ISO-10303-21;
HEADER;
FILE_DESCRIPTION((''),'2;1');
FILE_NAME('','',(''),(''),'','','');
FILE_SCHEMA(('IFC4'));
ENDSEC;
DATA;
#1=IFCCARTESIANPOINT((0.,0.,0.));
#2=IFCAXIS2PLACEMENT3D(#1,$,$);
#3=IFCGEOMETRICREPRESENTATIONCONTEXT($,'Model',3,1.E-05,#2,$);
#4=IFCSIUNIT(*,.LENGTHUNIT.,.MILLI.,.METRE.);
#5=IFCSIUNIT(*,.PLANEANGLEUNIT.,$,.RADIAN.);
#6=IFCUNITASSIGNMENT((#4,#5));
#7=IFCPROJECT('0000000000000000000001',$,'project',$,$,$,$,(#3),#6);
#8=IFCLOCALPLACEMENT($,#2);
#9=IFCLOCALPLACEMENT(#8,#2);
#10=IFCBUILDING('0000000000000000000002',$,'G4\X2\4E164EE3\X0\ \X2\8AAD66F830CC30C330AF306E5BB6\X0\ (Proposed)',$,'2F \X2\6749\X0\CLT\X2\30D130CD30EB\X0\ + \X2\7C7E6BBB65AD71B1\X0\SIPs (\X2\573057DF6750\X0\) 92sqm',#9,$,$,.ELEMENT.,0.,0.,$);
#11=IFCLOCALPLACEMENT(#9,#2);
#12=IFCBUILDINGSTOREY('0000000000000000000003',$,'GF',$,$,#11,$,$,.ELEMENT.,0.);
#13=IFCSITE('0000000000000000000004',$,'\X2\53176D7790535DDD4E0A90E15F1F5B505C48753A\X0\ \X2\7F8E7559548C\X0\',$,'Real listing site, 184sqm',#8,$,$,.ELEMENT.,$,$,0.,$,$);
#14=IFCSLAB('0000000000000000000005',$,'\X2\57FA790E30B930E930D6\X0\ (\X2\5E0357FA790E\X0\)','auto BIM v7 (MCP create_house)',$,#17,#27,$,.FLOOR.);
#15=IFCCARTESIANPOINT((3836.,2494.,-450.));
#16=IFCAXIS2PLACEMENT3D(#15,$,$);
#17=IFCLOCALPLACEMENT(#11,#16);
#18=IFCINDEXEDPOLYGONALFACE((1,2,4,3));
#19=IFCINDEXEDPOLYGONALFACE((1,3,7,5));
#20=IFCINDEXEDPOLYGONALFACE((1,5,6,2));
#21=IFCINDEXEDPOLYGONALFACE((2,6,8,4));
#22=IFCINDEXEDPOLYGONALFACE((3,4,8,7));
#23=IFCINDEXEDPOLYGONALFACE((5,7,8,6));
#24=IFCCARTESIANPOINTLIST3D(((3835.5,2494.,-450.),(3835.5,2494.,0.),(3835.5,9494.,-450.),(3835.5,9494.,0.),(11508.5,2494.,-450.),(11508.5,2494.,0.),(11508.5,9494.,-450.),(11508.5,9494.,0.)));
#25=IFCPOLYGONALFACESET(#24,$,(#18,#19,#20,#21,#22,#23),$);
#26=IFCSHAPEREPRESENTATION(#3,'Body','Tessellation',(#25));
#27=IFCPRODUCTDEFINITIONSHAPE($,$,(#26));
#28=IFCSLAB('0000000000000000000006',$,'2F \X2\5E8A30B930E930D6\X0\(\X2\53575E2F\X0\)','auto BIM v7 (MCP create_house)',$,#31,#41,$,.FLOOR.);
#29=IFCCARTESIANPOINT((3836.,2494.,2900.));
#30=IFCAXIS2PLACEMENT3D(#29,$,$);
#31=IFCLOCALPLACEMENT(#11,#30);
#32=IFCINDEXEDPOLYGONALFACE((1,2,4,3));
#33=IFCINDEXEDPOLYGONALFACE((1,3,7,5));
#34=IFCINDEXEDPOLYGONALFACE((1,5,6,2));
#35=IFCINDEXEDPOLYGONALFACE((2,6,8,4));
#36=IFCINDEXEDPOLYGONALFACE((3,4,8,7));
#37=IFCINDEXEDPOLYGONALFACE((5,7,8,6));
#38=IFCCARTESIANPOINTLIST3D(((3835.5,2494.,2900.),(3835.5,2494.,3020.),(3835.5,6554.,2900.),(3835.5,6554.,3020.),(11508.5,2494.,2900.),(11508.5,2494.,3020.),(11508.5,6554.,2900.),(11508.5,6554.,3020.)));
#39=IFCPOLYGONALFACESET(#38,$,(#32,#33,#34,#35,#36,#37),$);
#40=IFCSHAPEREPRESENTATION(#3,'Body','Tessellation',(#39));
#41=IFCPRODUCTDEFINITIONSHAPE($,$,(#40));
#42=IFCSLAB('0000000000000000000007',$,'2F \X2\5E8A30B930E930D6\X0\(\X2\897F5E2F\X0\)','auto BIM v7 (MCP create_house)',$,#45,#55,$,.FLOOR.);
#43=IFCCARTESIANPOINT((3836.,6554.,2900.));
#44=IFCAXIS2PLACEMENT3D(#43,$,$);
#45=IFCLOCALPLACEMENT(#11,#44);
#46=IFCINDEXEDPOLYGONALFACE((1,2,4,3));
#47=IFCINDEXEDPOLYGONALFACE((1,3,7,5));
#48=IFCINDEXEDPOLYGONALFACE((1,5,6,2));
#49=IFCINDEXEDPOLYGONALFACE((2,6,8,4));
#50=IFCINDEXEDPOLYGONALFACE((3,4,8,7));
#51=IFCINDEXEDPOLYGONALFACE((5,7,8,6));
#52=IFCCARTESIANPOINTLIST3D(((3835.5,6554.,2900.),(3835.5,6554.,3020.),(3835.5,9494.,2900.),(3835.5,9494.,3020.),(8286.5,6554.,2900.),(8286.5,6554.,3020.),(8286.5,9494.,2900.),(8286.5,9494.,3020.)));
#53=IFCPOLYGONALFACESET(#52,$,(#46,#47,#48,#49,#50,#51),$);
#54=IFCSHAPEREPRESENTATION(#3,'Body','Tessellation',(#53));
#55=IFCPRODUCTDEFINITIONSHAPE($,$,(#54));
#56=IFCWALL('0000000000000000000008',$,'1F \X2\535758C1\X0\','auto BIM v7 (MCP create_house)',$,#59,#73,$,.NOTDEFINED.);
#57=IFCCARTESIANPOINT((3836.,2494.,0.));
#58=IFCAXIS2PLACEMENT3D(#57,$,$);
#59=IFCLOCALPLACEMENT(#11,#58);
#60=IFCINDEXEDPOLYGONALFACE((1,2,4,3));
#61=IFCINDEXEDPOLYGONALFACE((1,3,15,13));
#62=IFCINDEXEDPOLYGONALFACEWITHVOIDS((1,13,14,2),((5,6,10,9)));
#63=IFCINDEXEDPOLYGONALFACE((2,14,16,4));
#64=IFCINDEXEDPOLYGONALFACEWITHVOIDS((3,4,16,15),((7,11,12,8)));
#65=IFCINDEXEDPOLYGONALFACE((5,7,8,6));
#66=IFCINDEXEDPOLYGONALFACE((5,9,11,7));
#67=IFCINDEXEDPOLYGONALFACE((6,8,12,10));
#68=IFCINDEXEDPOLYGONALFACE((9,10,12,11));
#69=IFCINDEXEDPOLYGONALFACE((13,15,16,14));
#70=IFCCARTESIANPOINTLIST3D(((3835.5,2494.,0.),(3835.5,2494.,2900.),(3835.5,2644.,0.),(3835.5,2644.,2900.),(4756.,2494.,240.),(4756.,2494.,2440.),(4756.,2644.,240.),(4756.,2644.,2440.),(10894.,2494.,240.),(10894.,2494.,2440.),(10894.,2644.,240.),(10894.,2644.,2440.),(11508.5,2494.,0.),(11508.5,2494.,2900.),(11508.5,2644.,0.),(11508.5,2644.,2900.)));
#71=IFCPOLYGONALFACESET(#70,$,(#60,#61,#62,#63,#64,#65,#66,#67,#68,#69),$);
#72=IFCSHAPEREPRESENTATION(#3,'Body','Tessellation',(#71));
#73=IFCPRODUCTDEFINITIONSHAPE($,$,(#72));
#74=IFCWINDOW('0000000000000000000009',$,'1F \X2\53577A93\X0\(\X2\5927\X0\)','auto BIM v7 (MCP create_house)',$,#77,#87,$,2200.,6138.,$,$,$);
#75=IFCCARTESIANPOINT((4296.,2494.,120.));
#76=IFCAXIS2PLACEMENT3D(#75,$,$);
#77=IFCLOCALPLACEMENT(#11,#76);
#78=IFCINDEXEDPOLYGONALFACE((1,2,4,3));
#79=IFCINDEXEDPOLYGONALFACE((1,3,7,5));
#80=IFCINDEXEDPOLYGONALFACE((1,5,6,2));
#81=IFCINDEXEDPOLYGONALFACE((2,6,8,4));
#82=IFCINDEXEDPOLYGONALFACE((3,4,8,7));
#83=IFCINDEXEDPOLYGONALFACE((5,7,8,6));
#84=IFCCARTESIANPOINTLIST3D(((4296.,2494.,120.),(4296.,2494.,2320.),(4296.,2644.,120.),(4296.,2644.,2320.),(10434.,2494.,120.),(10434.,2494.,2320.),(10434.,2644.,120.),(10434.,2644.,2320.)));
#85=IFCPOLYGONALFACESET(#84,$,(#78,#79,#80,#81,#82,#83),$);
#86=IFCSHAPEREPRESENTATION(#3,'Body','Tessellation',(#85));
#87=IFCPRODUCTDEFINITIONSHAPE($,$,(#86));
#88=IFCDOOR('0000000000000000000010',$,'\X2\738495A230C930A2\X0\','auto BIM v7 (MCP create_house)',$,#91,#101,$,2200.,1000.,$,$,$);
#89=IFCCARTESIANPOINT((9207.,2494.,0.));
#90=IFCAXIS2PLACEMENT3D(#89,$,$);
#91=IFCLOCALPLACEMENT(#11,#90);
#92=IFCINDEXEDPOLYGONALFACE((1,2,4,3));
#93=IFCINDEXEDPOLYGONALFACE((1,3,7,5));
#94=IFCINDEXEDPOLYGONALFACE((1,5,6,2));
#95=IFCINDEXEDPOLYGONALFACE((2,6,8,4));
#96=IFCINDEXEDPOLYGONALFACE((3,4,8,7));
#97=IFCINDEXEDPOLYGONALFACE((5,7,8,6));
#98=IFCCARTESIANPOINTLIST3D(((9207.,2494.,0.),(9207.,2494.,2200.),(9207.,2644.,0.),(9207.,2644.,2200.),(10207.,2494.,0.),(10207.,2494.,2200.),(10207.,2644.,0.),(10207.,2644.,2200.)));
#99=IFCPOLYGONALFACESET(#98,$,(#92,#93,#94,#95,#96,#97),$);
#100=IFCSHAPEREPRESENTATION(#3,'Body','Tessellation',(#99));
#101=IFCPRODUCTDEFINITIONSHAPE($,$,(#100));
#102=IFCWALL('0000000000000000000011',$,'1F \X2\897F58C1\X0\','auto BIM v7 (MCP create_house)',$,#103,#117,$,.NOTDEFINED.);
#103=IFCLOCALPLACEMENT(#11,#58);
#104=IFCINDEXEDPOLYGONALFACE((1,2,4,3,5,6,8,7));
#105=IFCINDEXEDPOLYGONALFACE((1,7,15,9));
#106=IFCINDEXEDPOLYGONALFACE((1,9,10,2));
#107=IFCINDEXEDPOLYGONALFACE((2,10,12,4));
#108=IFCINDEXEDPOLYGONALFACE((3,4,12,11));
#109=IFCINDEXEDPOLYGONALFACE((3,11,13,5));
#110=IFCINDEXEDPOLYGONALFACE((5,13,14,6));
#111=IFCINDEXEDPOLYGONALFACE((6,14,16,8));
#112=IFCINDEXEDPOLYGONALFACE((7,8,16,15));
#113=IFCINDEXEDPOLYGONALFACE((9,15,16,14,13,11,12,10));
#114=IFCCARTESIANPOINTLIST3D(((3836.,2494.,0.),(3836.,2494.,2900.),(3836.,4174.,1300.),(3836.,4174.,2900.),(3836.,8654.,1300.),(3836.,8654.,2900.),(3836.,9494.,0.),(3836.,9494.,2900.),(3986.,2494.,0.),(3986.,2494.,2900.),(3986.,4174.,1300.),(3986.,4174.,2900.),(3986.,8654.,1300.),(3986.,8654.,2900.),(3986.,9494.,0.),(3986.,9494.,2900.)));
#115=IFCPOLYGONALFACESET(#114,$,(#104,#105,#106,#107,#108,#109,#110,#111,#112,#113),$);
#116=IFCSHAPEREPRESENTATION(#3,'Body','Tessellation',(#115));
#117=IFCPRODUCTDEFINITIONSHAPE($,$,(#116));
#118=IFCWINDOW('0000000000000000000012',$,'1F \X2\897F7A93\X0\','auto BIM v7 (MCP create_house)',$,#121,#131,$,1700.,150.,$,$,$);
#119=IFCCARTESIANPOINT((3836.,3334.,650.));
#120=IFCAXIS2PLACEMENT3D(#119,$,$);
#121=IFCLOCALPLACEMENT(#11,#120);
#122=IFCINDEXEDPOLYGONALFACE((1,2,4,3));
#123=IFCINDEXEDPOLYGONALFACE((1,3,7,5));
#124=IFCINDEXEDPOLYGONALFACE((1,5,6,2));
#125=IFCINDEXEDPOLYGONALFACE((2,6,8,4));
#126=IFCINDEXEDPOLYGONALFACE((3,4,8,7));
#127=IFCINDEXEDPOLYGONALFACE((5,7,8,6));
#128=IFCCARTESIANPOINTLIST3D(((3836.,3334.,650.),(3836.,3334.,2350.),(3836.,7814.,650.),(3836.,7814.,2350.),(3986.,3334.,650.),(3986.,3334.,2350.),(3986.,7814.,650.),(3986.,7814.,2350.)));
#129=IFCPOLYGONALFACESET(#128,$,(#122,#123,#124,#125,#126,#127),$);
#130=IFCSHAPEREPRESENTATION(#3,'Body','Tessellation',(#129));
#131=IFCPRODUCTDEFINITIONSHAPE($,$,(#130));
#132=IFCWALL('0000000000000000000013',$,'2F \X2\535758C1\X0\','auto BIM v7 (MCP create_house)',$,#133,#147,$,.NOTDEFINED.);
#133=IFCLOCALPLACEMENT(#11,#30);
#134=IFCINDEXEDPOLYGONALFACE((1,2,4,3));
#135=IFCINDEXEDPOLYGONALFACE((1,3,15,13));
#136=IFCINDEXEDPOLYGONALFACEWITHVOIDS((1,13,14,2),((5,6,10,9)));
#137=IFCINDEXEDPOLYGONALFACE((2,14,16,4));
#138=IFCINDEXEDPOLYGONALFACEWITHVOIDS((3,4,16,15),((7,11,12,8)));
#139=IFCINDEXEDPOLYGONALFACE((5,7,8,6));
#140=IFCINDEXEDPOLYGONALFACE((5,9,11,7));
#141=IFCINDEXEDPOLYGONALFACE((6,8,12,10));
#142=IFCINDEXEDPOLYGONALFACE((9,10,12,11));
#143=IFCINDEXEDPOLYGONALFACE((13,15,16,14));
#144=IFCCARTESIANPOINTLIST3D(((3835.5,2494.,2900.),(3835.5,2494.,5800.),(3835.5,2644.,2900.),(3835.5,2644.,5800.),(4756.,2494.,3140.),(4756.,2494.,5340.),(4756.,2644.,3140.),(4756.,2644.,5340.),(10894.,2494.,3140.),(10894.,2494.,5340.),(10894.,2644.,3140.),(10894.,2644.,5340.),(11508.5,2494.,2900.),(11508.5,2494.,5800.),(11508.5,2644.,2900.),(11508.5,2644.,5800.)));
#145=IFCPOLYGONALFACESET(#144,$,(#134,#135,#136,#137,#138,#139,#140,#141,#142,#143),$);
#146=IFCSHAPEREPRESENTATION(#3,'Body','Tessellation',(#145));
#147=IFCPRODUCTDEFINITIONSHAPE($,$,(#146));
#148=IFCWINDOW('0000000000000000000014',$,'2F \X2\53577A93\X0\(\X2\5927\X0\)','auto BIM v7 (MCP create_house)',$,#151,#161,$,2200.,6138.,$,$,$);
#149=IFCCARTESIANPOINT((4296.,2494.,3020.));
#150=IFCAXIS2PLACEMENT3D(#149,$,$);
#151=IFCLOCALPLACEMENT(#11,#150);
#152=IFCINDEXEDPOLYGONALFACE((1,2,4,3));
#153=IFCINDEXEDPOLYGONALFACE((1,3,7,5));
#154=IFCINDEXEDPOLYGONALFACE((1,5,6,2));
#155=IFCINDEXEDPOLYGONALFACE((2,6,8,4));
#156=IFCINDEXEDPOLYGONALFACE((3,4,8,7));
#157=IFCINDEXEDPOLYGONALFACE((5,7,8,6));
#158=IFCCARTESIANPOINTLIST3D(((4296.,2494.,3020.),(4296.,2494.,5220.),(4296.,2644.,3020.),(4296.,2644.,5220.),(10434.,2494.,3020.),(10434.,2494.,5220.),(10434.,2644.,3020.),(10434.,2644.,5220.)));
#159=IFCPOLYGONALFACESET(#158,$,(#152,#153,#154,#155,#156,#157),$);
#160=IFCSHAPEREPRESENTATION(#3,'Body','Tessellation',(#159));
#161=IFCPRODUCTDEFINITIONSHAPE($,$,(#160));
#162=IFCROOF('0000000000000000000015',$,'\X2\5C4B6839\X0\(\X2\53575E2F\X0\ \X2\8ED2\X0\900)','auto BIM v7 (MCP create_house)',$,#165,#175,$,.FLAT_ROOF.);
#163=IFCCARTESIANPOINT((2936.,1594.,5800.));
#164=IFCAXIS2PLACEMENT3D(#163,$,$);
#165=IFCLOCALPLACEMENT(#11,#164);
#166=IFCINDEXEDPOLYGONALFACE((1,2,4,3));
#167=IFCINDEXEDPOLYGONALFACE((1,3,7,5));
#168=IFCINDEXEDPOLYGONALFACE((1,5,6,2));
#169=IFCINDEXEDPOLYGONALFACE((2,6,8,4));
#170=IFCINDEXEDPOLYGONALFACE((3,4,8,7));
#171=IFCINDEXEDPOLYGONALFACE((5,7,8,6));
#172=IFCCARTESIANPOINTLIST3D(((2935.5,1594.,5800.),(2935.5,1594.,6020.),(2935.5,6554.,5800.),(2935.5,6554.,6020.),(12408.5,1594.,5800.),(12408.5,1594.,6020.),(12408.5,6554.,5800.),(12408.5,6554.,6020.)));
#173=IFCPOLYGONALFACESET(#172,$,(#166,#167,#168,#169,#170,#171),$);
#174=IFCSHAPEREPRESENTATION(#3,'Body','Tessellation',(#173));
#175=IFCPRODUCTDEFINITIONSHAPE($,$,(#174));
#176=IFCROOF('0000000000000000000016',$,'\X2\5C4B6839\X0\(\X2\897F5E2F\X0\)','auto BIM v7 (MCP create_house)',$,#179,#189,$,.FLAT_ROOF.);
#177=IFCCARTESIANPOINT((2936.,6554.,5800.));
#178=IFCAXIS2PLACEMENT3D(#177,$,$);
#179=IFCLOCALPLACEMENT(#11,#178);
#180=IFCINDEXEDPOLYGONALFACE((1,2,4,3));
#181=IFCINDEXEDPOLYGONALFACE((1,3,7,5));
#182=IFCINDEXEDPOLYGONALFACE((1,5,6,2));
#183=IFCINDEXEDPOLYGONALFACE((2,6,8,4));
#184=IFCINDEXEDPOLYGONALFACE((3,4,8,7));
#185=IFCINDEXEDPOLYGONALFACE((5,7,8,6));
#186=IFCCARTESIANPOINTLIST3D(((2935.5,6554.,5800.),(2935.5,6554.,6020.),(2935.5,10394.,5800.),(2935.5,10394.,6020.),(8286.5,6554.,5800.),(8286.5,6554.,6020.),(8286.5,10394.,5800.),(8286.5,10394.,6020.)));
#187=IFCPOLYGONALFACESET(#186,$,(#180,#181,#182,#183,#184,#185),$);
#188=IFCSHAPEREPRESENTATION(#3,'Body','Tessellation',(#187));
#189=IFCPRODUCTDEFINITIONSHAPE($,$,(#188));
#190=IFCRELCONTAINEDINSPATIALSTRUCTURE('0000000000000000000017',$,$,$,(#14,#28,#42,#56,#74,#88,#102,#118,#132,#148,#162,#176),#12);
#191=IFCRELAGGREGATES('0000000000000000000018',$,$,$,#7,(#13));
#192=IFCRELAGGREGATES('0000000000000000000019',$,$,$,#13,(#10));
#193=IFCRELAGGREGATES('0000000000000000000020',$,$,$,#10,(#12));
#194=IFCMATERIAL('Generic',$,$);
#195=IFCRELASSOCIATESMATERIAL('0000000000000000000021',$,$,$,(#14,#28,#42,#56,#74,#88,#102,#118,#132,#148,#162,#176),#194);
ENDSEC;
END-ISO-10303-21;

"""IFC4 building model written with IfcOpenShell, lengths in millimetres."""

from ifc_helpers import new_model, si_unit, frame, frame_2d, origin, place, context, project, spatial, rectangle, extrude, material, element, fill, save


model = new_model("IFC4")

# Units and contexts
model_context = context("Model", 3, precision=1e-05, world=origin())
ifc_project = project(units=[si_unit("LENGTHUNIT", "METRE", prefix="MILLI"), si_unit("PLANEANGLEUNIT", "RADIAN")], contexts=[model_context])

# Site, building, storey
site_placement = place(None, origin())
site = spatial("IfcSite", under=ifc_project, at=site_placement, Name="北海道川上郡弟子屈町 美留和", ObjectType="Real listing site, 184sqm", CompositionType="ELEMENT", RefElevation=0.0)
building_placement = place(site_placement, origin())
building = spatial("IfcBuilding", under=site, at=building_placement, Name="G4世代 読書ヌックの家 (Proposed)", ObjectType="2F 杉CLTパネル + 籾殻断熱SIPs (地域材) 92sqm", CompositionType="ELEMENT", ElevationOfRefHeight=0.0, ElevationOfTerrain=0.0)
storey_placement = place(building_placement, origin())
storey = spatial("IfcBuildingStorey", under=building, at=storey_placement, Name="GF", CompositionType="ELEMENT", Elevation=0.0)

# Slabs
ifc_material = material(Name="Generic")
slab_1_placement = place(storey_placement, frame((3836.0, 2494.0, -450.0)))
element("IfcSlab", 1, at=slab_1_placement, inside=storey, material=ifc_material, Name="基礎スラブ (布基礎)", Description="auto BIM v7 (MCP create_house)", PredefinedType="FLOOR", context=model_context, shape_type="SweptSolid", body=[
    extrude(rectangle(XDim=7673.0, YDim=7000.0, at=frame_2d((3836.0, 3500.0))), frame((3836.0, 2494.0, -450.0)), (0.0, 0.0, 1.0), 450.0),
])
slab_2_placement = place(storey_placement, frame((3836.0, 2494.0, 2900.0)))
element("IfcSlab", 2, at=slab_2_placement, inside=storey, material=ifc_material, Name="2F 床スラブ(南帯)", Description="auto BIM v7 (MCP create_house)", PredefinedType="FLOOR", context=model_context, shape_type="SweptSolid", body=[
    extrude(rectangle(XDim=7673.0, YDim=4060.0, at=frame_2d((3836.0, 2030.0))), frame((3836.0, 2494.0, 2900.0)), (0.0, 0.0, 1.0), 120.0),
])
slab_3_placement = place(storey_placement, frame((3836.0, 6554.0, 2900.0)))
element("IfcSlab", 3, at=slab_3_placement, inside=storey, material=ifc_material, Name="2F 床スラブ(西帯)", Description="auto BIM v7 (MCP create_house)", PredefinedType="FLOOR", context=model_context, shape_type="SweptSolid", body=[
    extrude(rectangle(XDim=4451.0, YDim=2940.0, at=frame_2d((2225.0, 1470.0))), frame((3836.0, 6554.0, 2900.0)), (0.0, 0.0, 1.0), 120.0),
])

# Wall, openings, window, door
wall_1_placement = place(storey_placement, frame((3836.0, 2494.0, 0.0)))
wall_1 = element("IfcWall", 4, at=wall_1_placement, inside=storey, material=ifc_material, Name="1F 南壁", Description="auto BIM v7 (MCP create_house)", PredefinedType="NOTDEFINED", context=model_context, shape_type="SweptSolid", body=[
    extrude(rectangle(XDim=7673.0, YDim=150.0, at=frame_2d((3836.0, 75.0))), frame((3836.0, 2494.0, 0.0)), (0.0, 0.0, 1.0), 2900.0),
])
opening_1_placement = place(storey_placement, frame((4296.0, 2494.0, 120.0)))
opening_1 = element("IfcOpeningElement", 5, at=opening_1_placement, cuts=wall_1, PredefinedType="NOTDEFINED", context=model_context, shape_type="SweptSolid", body=[
    extrude(rectangle(XDim=6138.0, YDim=150.0, at=frame_2d((3069.0, 75.0))), frame((4296.0, 2494.0, 120.0)), (0.0, 0.0, 1.0), 2200.0),
])
opening_2_placement = place(storey_placement, frame((9207.0, 2494.0, 0.0)))
opening_2 = element("IfcOpeningElement", 6, at=opening_2_placement, cuts=wall_1, PredefinedType="NOTDEFINED", context=model_context, shape_type="SweptSolid", body=[
    extrude(rectangle(XDim=1000.0, YDim=150.0, at=frame_2d((500.0, 75.0))), frame((9207.0, 2494.0, 0.0)), (0.0, 0.0, 1.0), 2200.0),
])
window_1_placement = place(storey_placement, frame((4296.0, 2494.0, 120.0)))
window_1 = element("IfcWindow", 7, at=window_1_placement, inside=storey, material=ifc_material, Name="1F 南窓(大)", Description="auto BIM v7 (MCP create_house)", OverallHeight=2200.0, OverallWidth=6138.0, context=model_context, shape_type="SweptSolid", body=[
    extrude(rectangle(XDim=6138.0, YDim=150.0, at=frame_2d((3069.0, 75.0))), frame((4296.0, 2494.0, 120.0)), (0.0, 0.0, 1.0), 2200.0),
])
fill(opening_1, window_1)
door_placement = place(storey_placement, frame((9207.0, 2494.0, 0.0)))
door = element("IfcDoor", 8, at=door_placement, inside=storey, material=ifc_material, Name="玄関ドア", Description="auto BIM v7 (MCP create_house)", OverallHeight=2200.0, OverallWidth=1000.0, context=model_context, shape_type="SweptSolid", body=[
    extrude(rectangle(XDim=1000.0, YDim=150.0, at=frame_2d((500.0, 75.0))), frame((9207.0, 2494.0, 0.0)), (0.0, 0.0, 1.0), 2200.0),
])
fill(opening_2, door)

# Wall, opening, window
wall_2_placement = place(storey_placement, frame((3836.0, 2494.0, 0.0)))
wall_2 = element("IfcWall", 9, at=wall_2_placement, inside=storey, material=ifc_material, Name="1F 西壁", Description="auto BIM v7 (MCP create_house)", PredefinedType="NOTDEFINED", context=model_context, shape_type="SweptSolid", body=[
    extrude(rectangle(XDim=150.0, YDim=7000.0, at=frame_2d((75.0, 3500.0))), frame((3836.0, 2494.0, 0.0)), (0.0, 0.0, 1.0), 2900.0),
])
opening_3_placement = place(storey_placement, frame((3836.0, 3334.0, 650.0)))
opening_3 = element("IfcOpeningElement", 10, at=opening_3_placement, cuts=wall_2, PredefinedType="NOTDEFINED", context=model_context, shape_type="SweptSolid", body=[
    extrude(rectangle(XDim=150.0, YDim=4480.0, at=frame_2d((75.0, 2240.0))), frame((3836.0, 3334.0, 650.0)), (0.0, 0.0, 1.0), 1700.0),
])
window_2_placement = place(storey_placement, frame((3836.0, 3334.0, 650.0)))
window_2 = element("IfcWindow", 11, at=window_2_placement, inside=storey, material=ifc_material, Name="1F 西窓", Description="auto BIM v7 (MCP create_house)", OverallHeight=1700.0, OverallWidth=150.0, context=model_context, shape_type="SweptSolid", body=[
    extrude(rectangle(XDim=150.0, YDim=4480.0, at=frame_2d((75.0, 2240.0))), frame((3836.0, 3334.0, 650.0)), (0.0, 0.0, 1.0), 1700.0),
])
fill(opening_3, window_2)

# Wall, opening, window
wall_3_placement = place(storey_placement, frame((3836.0, 2494.0, 2900.0)))
wall_3 = element("IfcWall", 12, at=wall_3_placement, inside=storey, material=ifc_material, Name="2F 南壁", Description="auto BIM v7 (MCP create_house)", PredefinedType="NOTDEFINED", context=model_context, shape_type="SweptSolid", body=[
    extrude(rectangle(XDim=7673.0, YDim=150.0, at=frame_2d((3836.0, 75.0))), frame((3836.0, 2494.0, 2900.0)), (0.0, 0.0, 1.0), 2900.0),
])
opening_4_placement = place(storey_placement, frame((4296.0, 2494.0, 3020.0)))
opening_4 = element("IfcOpeningElement", 13, at=opening_4_placement, cuts=wall_3, PredefinedType="NOTDEFINED", context=model_context, shape_type="SweptSolid", body=[
    extrude(rectangle(XDim=6138.0, YDim=150.0, at=frame_2d((3069.0, 75.0))), frame((4296.0, 2494.0, 3020.0)), (0.0, 0.0, 1.0), 2200.0),
])
window_3_placement = place(storey_placement, frame((4296.0, 2494.0, 3020.0)))
window_3 = element("IfcWindow", 14, at=window_3_placement, inside=storey, material=ifc_material, Name="2F 南窓(大)", Description="auto BIM v7 (MCP create_house)", OverallHeight=2200.0, OverallWidth=6138.0, context=model_context, shape_type="SweptSolid", body=[
    extrude(rectangle(XDim=6138.0, YDim=150.0, at=frame_2d((3069.0, 75.0))), frame((4296.0, 2494.0, 3020.0)), (0.0, 0.0, 1.0), 2200.0),
])
fill(opening_4, window_3)

# Roofs
roof_1_placement = place(storey_placement, frame((2936.0, 1594.0, 5800.0)))
element("IfcRoof", 15, at=roof_1_placement, inside=storey, material=ifc_material, Name="屋根(南帯 軒900)", Description="auto BIM v7 (MCP create_house)", PredefinedType="FLAT_ROOF", context=model_context, shape_type="SweptSolid", body=[
    extrude(rectangle(XDim=9473.0, YDim=4960.0, at=frame_2d((4736.0, 2480.0))), frame((2936.0, 1594.0, 5800.0)), (0.0, 0.0, 1.0), 220.0),
])
roof_2_placement = place(storey_placement, frame((2936.0, 6554.0, 5800.0)))
element("IfcRoof", 16, at=roof_2_placement, inside=storey, material=ifc_material, Name="屋根(西帯)", Description="auto BIM v7 (MCP create_house)", PredefinedType="FLAT_ROOF", context=model_context, shape_type="SweptSolid", body=[
    extrude(rectangle(XDim=5351.0, YDim=3840.0, at=frame_2d((2675.0, 1920.0))), frame((2936.0, 6554.0, 5800.0)), (0.0, 0.0, 1.0), 220.0),
])

save(model, "model.ifc")
